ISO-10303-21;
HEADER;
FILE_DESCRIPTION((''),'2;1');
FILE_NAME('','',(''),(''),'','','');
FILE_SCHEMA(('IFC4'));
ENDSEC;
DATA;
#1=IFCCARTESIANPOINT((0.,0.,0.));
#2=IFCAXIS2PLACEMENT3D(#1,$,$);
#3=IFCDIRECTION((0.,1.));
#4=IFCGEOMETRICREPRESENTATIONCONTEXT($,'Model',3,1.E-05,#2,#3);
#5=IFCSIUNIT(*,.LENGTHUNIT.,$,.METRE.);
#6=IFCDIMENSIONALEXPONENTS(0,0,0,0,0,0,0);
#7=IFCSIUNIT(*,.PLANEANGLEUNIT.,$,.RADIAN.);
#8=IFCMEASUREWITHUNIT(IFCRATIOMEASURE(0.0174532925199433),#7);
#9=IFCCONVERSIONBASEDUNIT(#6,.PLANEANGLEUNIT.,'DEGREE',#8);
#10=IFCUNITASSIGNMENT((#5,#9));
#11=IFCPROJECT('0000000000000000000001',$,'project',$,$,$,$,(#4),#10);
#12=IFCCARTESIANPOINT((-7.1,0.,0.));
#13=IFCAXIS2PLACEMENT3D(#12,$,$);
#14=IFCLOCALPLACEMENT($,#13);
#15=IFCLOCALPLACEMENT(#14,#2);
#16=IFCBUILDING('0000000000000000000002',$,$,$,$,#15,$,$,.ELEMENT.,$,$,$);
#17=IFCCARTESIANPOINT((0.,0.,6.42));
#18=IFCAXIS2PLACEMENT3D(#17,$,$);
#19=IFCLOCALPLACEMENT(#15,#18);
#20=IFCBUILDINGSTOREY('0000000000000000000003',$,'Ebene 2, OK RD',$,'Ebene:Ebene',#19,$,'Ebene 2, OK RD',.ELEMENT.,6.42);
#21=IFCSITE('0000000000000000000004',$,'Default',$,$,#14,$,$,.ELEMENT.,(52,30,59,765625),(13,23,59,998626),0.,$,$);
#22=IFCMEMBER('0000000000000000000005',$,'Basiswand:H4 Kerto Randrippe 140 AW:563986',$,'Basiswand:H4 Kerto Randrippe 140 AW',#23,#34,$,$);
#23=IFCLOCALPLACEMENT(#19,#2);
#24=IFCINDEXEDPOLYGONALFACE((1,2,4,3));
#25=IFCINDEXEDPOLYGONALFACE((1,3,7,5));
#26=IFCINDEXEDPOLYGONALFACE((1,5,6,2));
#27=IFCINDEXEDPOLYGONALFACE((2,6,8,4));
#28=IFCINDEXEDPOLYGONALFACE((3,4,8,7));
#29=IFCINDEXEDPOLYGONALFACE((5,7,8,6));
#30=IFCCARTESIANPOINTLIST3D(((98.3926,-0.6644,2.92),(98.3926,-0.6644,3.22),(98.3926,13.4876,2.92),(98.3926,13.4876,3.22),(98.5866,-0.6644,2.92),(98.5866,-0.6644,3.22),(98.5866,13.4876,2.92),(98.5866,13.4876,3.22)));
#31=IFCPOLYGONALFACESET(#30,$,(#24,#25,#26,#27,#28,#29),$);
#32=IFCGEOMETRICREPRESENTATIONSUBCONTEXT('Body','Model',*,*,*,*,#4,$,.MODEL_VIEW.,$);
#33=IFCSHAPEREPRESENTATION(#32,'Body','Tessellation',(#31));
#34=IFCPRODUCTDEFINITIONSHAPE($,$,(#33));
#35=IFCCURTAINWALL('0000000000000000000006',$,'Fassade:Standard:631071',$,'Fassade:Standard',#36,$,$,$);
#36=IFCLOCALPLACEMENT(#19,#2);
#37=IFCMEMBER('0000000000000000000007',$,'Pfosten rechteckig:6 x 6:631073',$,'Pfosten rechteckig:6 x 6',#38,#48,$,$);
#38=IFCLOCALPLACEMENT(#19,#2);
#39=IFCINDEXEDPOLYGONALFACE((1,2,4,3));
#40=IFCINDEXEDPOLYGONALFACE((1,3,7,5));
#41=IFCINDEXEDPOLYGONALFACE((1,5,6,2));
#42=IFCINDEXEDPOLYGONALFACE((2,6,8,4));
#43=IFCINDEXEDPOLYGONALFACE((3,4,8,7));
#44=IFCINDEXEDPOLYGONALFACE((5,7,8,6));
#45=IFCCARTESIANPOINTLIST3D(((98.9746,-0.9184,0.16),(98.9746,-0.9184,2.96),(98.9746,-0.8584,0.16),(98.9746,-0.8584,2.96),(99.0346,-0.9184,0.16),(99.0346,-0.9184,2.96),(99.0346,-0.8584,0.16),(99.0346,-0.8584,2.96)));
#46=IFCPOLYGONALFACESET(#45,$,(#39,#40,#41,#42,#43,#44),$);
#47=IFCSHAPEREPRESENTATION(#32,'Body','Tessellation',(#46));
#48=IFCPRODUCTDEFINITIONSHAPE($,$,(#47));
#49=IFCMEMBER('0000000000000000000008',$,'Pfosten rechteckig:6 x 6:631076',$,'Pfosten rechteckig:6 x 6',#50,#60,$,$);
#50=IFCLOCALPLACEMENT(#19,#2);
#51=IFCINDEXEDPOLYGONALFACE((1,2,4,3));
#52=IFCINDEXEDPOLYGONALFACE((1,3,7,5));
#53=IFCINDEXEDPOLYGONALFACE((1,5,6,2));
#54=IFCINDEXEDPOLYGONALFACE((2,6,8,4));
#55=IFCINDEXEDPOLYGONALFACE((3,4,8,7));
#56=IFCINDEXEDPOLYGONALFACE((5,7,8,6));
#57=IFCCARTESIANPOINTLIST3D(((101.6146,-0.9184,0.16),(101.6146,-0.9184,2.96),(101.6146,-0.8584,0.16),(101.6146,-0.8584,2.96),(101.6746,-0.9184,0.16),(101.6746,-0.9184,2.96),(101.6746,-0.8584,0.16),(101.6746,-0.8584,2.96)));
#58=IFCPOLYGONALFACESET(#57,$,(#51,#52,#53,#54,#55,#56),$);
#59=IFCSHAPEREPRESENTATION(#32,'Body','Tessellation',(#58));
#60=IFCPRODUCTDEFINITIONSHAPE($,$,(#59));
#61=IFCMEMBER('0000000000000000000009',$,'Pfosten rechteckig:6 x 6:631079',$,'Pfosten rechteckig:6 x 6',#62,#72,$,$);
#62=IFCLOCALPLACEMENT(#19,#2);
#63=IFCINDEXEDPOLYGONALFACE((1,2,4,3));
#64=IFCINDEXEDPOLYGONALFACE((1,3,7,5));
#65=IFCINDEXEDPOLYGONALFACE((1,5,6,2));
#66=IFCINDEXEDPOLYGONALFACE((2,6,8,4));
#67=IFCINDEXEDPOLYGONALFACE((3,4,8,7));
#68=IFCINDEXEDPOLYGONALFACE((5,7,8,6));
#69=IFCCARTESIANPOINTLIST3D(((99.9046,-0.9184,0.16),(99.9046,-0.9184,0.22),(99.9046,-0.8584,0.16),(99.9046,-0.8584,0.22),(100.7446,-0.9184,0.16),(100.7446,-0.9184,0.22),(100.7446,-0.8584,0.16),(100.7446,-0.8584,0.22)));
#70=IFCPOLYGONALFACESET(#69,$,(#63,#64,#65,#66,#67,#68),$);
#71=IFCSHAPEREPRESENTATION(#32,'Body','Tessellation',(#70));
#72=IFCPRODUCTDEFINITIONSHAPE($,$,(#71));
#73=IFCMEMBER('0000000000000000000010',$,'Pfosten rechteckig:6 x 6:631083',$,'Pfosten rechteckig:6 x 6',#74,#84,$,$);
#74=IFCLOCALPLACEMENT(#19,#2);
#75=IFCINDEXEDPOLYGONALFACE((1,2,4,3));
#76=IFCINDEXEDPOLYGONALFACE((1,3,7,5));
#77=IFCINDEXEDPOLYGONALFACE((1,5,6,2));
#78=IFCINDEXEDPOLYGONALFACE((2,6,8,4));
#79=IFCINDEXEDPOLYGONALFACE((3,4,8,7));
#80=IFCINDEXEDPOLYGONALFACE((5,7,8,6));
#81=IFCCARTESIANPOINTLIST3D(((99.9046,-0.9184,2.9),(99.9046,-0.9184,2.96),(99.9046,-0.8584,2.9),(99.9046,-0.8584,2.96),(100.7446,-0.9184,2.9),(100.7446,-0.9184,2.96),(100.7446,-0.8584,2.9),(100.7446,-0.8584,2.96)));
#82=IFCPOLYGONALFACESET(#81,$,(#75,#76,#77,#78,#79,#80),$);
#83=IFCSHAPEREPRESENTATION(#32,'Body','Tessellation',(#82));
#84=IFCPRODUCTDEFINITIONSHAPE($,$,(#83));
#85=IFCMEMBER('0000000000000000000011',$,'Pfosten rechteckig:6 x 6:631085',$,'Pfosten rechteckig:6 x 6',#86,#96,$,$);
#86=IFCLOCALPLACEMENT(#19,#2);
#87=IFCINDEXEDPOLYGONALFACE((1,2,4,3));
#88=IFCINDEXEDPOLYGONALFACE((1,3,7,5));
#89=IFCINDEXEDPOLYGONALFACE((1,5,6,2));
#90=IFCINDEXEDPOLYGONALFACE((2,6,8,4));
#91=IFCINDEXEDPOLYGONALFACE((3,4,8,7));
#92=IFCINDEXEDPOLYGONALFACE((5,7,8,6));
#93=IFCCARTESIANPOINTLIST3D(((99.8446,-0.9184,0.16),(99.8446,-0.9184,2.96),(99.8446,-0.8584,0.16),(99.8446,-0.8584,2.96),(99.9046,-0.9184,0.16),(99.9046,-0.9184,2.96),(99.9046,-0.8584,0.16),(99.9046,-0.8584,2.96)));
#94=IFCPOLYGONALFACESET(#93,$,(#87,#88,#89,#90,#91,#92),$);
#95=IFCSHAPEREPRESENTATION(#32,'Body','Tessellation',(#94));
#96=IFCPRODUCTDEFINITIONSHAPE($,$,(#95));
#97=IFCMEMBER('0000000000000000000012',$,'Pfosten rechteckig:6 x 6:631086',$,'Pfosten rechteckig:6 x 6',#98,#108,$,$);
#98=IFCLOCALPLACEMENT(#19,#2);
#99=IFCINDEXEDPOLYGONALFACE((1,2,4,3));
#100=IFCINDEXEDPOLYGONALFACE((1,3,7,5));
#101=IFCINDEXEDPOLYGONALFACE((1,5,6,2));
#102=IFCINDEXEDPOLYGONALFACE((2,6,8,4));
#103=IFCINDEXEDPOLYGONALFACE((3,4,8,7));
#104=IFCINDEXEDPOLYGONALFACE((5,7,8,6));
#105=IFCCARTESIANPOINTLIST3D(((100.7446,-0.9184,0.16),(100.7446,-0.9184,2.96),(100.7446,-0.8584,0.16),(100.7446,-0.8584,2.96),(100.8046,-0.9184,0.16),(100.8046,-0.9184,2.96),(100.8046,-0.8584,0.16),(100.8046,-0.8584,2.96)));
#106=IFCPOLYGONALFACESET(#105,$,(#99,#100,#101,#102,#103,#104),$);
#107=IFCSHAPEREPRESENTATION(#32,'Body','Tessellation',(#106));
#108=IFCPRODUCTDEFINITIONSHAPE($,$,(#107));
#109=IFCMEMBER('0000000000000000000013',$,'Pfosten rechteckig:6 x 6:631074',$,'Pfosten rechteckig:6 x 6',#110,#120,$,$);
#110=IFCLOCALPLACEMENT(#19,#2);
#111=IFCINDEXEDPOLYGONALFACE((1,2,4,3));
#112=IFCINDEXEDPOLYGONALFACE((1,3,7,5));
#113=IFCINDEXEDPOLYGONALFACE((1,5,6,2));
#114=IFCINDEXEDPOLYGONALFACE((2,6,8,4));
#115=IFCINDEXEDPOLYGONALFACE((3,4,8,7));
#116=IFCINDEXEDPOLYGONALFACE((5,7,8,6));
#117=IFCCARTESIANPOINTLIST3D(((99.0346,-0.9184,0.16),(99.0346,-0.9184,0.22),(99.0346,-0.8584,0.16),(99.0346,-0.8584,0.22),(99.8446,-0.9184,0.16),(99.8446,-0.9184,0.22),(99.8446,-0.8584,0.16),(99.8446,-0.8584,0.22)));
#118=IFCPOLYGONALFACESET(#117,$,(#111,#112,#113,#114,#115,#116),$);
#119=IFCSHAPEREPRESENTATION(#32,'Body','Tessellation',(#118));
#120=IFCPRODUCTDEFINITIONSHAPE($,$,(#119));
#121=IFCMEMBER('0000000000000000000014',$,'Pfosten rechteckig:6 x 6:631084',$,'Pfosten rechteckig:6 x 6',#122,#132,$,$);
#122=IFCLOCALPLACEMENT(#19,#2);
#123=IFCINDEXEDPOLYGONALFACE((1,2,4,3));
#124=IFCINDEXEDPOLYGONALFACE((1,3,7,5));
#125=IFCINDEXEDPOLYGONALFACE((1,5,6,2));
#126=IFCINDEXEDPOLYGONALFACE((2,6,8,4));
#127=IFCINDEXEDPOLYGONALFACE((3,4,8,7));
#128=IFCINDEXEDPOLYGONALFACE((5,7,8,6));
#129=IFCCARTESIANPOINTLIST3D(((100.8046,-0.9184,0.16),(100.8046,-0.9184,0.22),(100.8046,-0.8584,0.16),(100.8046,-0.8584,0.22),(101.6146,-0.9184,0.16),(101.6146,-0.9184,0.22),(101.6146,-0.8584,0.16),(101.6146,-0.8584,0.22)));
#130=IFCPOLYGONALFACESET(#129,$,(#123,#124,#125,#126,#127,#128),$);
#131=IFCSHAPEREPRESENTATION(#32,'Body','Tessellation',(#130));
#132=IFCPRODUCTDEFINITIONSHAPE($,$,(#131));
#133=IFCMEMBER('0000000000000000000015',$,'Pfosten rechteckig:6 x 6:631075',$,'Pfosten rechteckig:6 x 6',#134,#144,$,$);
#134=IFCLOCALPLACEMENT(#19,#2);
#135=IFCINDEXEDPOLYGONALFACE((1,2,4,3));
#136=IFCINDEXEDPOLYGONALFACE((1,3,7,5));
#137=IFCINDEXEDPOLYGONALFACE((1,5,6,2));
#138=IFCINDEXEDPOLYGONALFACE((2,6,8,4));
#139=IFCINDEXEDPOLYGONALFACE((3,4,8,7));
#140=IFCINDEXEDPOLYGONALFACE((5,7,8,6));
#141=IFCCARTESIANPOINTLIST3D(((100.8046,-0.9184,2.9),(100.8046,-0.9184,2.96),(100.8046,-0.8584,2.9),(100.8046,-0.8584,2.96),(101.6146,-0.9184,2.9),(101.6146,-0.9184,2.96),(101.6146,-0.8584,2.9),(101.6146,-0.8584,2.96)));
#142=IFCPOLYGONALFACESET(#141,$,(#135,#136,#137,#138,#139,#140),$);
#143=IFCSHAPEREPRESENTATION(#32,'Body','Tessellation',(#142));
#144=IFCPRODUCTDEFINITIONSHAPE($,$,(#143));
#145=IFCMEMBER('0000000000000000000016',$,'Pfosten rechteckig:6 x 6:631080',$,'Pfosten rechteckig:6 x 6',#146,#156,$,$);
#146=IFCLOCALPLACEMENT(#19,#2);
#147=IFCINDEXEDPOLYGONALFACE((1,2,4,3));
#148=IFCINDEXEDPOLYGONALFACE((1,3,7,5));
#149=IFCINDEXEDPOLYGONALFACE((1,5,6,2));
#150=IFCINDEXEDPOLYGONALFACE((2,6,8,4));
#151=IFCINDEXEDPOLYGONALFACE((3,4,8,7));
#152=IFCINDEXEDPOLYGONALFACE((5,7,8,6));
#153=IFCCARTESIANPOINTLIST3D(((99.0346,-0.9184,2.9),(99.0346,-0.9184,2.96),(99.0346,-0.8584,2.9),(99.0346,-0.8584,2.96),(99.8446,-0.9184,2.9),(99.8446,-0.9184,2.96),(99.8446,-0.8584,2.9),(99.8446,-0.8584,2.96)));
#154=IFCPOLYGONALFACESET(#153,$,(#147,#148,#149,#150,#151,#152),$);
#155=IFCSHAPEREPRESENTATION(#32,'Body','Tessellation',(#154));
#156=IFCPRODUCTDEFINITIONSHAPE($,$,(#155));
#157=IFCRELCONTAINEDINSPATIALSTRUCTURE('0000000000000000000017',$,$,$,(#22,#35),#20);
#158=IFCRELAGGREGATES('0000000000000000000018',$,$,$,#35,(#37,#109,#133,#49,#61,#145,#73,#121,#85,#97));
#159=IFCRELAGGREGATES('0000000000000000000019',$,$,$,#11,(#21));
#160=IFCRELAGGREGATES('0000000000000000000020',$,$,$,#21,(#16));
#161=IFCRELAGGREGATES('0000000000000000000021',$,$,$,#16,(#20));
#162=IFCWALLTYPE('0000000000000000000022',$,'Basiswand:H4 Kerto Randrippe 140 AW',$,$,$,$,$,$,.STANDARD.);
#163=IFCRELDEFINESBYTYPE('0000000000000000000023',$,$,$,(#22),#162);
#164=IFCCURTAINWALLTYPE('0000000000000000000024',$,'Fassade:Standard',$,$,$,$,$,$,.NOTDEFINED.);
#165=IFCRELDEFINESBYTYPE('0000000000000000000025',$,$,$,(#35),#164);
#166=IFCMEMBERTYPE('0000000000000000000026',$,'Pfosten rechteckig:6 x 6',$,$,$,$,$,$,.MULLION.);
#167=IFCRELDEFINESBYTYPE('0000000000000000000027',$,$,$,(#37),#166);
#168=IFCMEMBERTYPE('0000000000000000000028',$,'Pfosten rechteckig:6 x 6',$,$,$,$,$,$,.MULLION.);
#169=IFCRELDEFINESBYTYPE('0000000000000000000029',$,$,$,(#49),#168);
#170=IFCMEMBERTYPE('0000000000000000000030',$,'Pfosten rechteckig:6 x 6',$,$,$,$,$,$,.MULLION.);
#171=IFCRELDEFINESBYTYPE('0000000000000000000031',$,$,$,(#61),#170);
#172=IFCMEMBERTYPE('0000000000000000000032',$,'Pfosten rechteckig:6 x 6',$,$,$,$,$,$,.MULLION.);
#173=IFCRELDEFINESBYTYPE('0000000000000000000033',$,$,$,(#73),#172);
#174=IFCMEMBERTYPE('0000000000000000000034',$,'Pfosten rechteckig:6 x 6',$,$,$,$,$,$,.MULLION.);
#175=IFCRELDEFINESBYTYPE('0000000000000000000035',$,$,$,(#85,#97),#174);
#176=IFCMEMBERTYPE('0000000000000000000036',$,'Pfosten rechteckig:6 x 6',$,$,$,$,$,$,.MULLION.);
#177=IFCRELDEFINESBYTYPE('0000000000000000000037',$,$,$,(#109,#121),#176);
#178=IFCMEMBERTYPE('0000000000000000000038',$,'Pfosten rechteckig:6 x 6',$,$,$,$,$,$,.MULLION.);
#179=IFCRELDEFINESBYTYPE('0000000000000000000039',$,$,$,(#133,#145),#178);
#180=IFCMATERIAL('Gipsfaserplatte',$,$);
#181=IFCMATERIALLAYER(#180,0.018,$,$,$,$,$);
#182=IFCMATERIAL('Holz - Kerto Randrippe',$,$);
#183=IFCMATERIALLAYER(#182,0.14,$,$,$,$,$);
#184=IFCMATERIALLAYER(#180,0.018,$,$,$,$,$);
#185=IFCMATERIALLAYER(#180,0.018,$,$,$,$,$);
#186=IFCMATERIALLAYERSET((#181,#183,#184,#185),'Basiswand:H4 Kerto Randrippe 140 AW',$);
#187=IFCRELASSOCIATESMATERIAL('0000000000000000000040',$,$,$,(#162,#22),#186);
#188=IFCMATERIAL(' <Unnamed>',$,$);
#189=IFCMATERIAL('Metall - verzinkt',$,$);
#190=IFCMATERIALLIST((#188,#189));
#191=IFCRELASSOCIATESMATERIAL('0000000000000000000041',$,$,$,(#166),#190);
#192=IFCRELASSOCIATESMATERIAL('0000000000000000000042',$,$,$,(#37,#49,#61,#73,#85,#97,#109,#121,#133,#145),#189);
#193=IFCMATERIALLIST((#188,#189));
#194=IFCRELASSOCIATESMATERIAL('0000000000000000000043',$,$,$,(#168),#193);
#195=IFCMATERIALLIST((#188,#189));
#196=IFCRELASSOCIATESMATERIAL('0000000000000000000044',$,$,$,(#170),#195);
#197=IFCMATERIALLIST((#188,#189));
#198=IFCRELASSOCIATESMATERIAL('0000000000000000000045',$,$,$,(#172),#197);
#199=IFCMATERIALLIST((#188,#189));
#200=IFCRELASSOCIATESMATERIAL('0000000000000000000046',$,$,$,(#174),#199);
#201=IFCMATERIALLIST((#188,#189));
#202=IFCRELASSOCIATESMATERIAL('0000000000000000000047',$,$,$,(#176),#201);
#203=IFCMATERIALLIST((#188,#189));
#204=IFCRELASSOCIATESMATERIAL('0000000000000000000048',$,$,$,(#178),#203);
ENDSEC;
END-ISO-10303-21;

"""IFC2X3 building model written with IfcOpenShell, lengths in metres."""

from ifc_helpers import new_model, entity, si_unit, converted_unit, direction, frame, frame_2d, origin, origin_2d_with_axis, place, context, subcontext, project, spatial, rectangle, extrude, source, transform, mapped, material, material_list, layer, layer_set, layer_usage, type_object, type_shapes, element, aggregate, save


model = new_model("IFC2X3")

# Units and contexts
model_context = context("Model", 3, precision=1e-05, world=origin(), true_north=direction((0.0, 1.0)))
body_context = subcontext(model_context, "Body", "Model", "MODEL_VIEW")
ifc_project = project(units=[si_unit("LENGTHUNIT", "METRE"), converted_unit("PLANEANGLEUNIT", "DEGREE", entity("IfcRatioMeasure", 0.0174532925199433), si_unit("PLANEANGLEUNIT", "RADIAN"), dimensions=[0, 0, 0, 0, 0, 0, 0])], contexts=[model_context])

# Site, building, storey
site_placement = place(None, frame((-7.1, 0.0, 0.0)))
site = spatial("IfcSite", under=ifc_project, at=site_placement, Name="Default", CompositionType="ELEMENT", RefLatitude=(52, 30, 59, 765625), RefLongitude=(13, 23, 59, 998626), RefElevation=0.0)
building_placement = place(site_placement, origin())
building = spatial("IfcBuilding", under=site, at=building_placement, CompositionType="ELEMENT")
storey_placement = place(building_placement, frame((0.0, 0.0, 6.42)))
storey = spatial("IfcBuildingStorey", under=building, at=storey_placement, Name="Ebene 2, OK RD", ObjectType="Ebene:Ebene", LongName="Ebene 2, OK RD", CompositionType="ELEMENT", Elevation=6.42)

# Member
ifc_material_1 = material(Name="Gipsfaserplatte")
ifc_layer_1 = layer(ifc_material_1, 0.018)
ifc_material_2 = material(Name="Holz - Kerto Randrippe")
ifc_layer_2 = layer(ifc_material_2, 0.14)
ifc_layer_3 = layer(ifc_material_1, 0.018)
ifc_layer_4 = layer(ifc_material_1, 0.018)
ifc_layer_set_1 = layer_set([ifc_layer_1, ifc_layer_2, ifc_layer_3, ifc_layer_4], Name="Basiswand:H4 Kerto Randrippe 140 AW")
ifc_layer_usage_1 = layer_usage(ifc_layer_set_1, "AXIS2", "NEGATIVE", 0.097)
wall_type_1 = type_object("IfcWallType", Name="Basiswand:H4 Kerto Randrippe 140 AW", PredefinedType="STANDARD", material=ifc_layer_set_1)
member_1_placement = place(storey_placement, frame((98.4896, -0.6644, 2.92), z_axis=(0.0, 0.0, 1.0), x_axis=(0.0, 1.0, 0.0)))
element("IfcMember", 1, at=member_1_placement, inside=storey, type_object=wall_type_1, material=ifc_layer_usage_1, Name="Basiswand:H4 Kerto Randrippe 140 AW:563986", ObjectType="Basiswand:H4 Kerto Randrippe 140 AW", context=body_context, shape_type="SweptSolid", body=[
    extrude(rectangle(XDim=14.152, YDim=0.194, at=frame_2d((7.076, 0.0), x_axis=(-1.0, 0.0))), origin(), (0.0, 0.0, 1.0), 0.3),
])

# Curtain wall, members
curtain_wall_type = type_object("IfcCurtainWallType", Name="Fassade:Standard", PredefinedType="NOTDEFINED")
curtain_wall_placement = place(storey_placement, frame((0.0, 0.0, -6.42)))
curtain_wall = element("IfcCurtainWall", 2, at=curtain_wall_placement, inside=storey, type_object=curtain_wall_type, Name="Fassade:Standard:631071", ObjectType="Fassade:Standard")
ifc_material_3 = material(Name="Metall - verzinkt")
ifc_material_4 = material(Name=" <Unnamed>")
ifc_material_list_1 = material_list([ifc_material_4, ifc_material_3])
member_type_1 = type_object("IfcMemberType", Name="Pfosten rechteckig:6 x 6", PredefinedType="MULLION", material=ifc_material_list_1)
shared_shape_1 = source(origin(), body_context, "Body", "SweptSolid", [
    extrude(rectangle(XDim=0.06, YDim=0.06, at=origin_2d_with_axis()), frame((-0.03, 0.0, -2.8), z_axis=(0.0, 0.0, 1.0), x_axis=(0.0, -1.0, 0.0)), (0.0, 0.0, 1.0), 2.8),
])
type_shapes(member_type_1, [shared_shape_1])
placement = place(building_placement, frame((0.0, 0.0, 3.26)))
member_2_placement = place(placement, frame((98.9746, -0.8884, 6.12), z_axis=(0.0, 0.0, 1.0), x_axis=(-1.0, 0.0, 0.0)))
member_2 = element("IfcMember", 3, at=member_2_placement, type_object=member_type_1, material=ifc_material_3, Name="Pfosten rechteckig:6 x 6:631073", ObjectType="Pfosten rechteckig:6 x 6", context=body_context, shape_type="MappedRepresentation", body=[
    mapped(shared_shape_1, transform((0.0, 0.0, 0.0), scale=1.0)),
])
ifc_material_list_2 = material_list([ifc_material_4, ifc_material_3])
member_type_2 = type_object("IfcMemberType", Name="Pfosten rechteckig:6 x 6", PredefinedType="MULLION", material=ifc_material_list_2)
shared_shape_2 = source(origin(), body_context, "Body", "SweptSolid", [
    extrude(rectangle(XDim=0.06, YDim=0.06, at=origin_2d_with_axis()), frame((-0.03, 0.0, -2.8), z_axis=(0.0, 0.0, 1.0), x_axis=(0.0, -1.0, 0.0)), (0.0, 0.0, 1.0), 2.8),
])
type_shapes(member_type_2, [shared_shape_2])
member_3_placement = place(placement, frame((101.6746, -0.8884, 3.32), z_axis=(0.0, 0.0, -1.0), x_axis=(1.0, 0.0, 0.0)))
member_3 = element("IfcMember", 4, at=member_3_placement, type_object=member_type_2, material=ifc_material_3, Name="Pfosten rechteckig:6 x 6:631076", ObjectType="Pfosten rechteckig:6 x 6", context=body_context, shape_type="MappedRepresentation", body=[
    mapped(shared_shape_2, transform((0.0, 0.0, 0.0), scale=1.0)),
])
ifc_material_list_3 = material_list([ifc_material_4, ifc_material_3])
member_type_3 = type_object("IfcMemberType", Name="Pfosten rechteckig:6 x 6", PredefinedType="MULLION", material=ifc_material_list_3)
shared_shape_3 = source(origin(), body_context, "Body", "SweptSolid", [
    extrude(rectangle(XDim=0.06, YDim=0.06, at=origin_2d_with_axis()), frame((-0.03, 0.0, -0.84), z_axis=(0.0, 0.0, 1.0), x_axis=(0.0, -1.0, 0.0)), (0.0, 0.0, 1.0), 0.84),
])
type_shapes(member_type_3, [shared_shape_3])
member_4_placement = place(placement, frame((99.9046, -0.8884, 3.32), z_axis=(-1.0, 0.0, 0.0), x_axis=(0.0, 0.0, -1.0)))
member_4 = element("IfcMember", 5, at=member_4_placement, type_object=member_type_3, material=ifc_material_3, Name="Pfosten rechteckig:6 x 6:631079", ObjectType="Pfosten rechteckig:6 x 6", context=body_context, shape_type="MappedRepresentation", body=[
    mapped(shared_shape_3, transform((0.0, 0.0, 0.0), scale=1.0)),
])
ifc_material_list_4 = material_list([ifc_material_4, ifc_material_3])
member_type_4 = type_object("IfcMemberType", Name="Pfosten rechteckig:6 x 6", PredefinedType="MULLION", material=ifc_material_list_4)
shared_shape_4 = source(origin(), body_context, "Body", "SweptSolid", [
    extrude(rectangle(XDim=0.06, YDim=0.06, at=origin_2d_with_axis()), frame((-0.03, 0.0, -0.84), z_axis=(0.0, 0.0, 1.0), x_axis=(0.0, -1.0, 0.0)), (0.0, 0.0, 1.0), 0.84),
])
type_shapes(member_type_4, [shared_shape_4])
member_5_placement = place(placement, frame((100.7446, -0.8884, 6.12), z_axis=(1.0, 0.0, 0.0), x_axis=(0.0, 0.0, 1.0)))
member_5 = element("IfcMember", 6, at=member_5_placement, type_object=member_type_4, material=ifc_material_3, Name="Pfosten rechteckig:6 x 6:631083", ObjectType="Pfosten rechteckig:6 x 6", context=body_context, shape_type="MappedRepresentation", body=[
    mapped(shared_shape_4, transform((0.0, 0.0, 0.0), scale=1.0)),
])
ifc_material_list_5 = material_list([ifc_material_4, ifc_material_3])
member_type_5 = type_object("IfcMemberType", Name="Pfosten rechteckig:6 x 6", PredefinedType="MULLION", material=ifc_material_list_5)
shared_shape_5 = source(origin(), body_context, "Body", "SweptSolid", [
    extrude(rectangle(XDim=0.06, YDim=0.06, at=origin_2d_with_axis()), frame((0.0, 0.0, -2.8), z_axis=(0.0, 0.0, 1.0), x_axis=(0.0, -1.0, 0.0)), (0.0, 0.0, 1.0), 2.8),
])
type_shapes(member_type_5, [shared_shape_5])
member_6_placement = place(placement, frame((99.8746, -0.8884, 3.32), z_axis=(0.0, 0.0, -1.0), x_axis=(1.0, 0.0, 0.0)))
member_6 = element("IfcMember", 7, at=member_6_placement, type_object=member_type_5, material=ifc_material_3, Name="Pfosten rechteckig:6 x 6:631085", ObjectType="Pfosten rechteckig:6 x 6", context=body_context, shape_type="MappedRepresentation", body=[
    mapped(shared_shape_5, transform((0.0, 0.0, 0.0), scale=1.0)),
])
member_7_placement = place(placement, frame((100.7746, -0.8884, 3.32), z_axis=(0.0, 0.0, -1.0), x_axis=(1.0, 0.0, 0.0)))
member_7 = element("IfcMember", 8, at=member_7_placement, type_object=member_type_5, material=ifc_material_3, Name="Pfosten rechteckig:6 x 6:631086", ObjectType="Pfosten rechteckig:6 x 6", context=body_context, shape_type="MappedRepresentation", body=[
    mapped(shared_shape_5, transform((0.0, 0.0, 0.0), scale=1.0)),
])
ifc_material_list_6 = material_list([ifc_material_4, ifc_material_3])
member_type_6 = type_object("IfcMemberType", Name="Pfosten rechteckig:6 x 6", PredefinedType="MULLION", material=ifc_material_list_6)
shared_shape_6 = source(origin(), body_context, "Body", "SweptSolid", [
    extrude(rectangle(XDim=0.06, YDim=0.06, at=origin_2d_with_axis()), frame((-0.03, 0.0, -0.81), z_axis=(0.0, 0.0, 1.0), x_axis=(0.0, -1.0, 0.0)), (0.0, 0.0, 1.0), 0.81),
])
type_shapes(member_type_6, [shared_shape_6])
member_8_placement = place(placement, frame((99.0346, -0.8884, 3.32), z_axis=(-1.0, 0.0, 0.0), x_axis=(0.0, 0.0, -1.0)))
member_8 = element("IfcMember", 9, at=member_8_placement, type_object=member_type_6, material=ifc_material_3, Name="Pfosten rechteckig:6 x 6:631074", ObjectType="Pfosten rechteckig:6 x 6", context=body_context, shape_type="MappedRepresentation", body=[
    mapped(shared_shape_6, transform((0.0, 0.0, 0.0), scale=1.0)),
])
member_9_placement = place(placement, frame((100.8046, -0.8884, 3.32), z_axis=(-1.0, 0.0, 0.0), x_axis=(0.0, 0.0, -1.0)))
member_9 = element("IfcMember", 10, at=member_9_placement, type_object=member_type_6, material=ifc_material_3, Name="Pfosten rechteckig:6 x 6:631084", ObjectType="Pfosten rechteckig:6 x 6", context=body_context, shape_type="MappedRepresentation", body=[
    mapped(shared_shape_6, transform((0.0, 0.0, 0.0), scale=1.0)),
])
ifc_material_list_7 = material_list([ifc_material_4, ifc_material_3])
member_type_7 = type_object("IfcMemberType", Name="Pfosten rechteckig:6 x 6", PredefinedType="MULLION", material=ifc_material_list_7)
shared_shape_7 = source(origin(), body_context, "Body", "SweptSolid", [
    extrude(rectangle(XDim=0.06, YDim=0.06, at=origin_2d_with_axis()), frame((-0.03, 0.0, -0.81), z_axis=(0.0, 0.0, 1.0), x_axis=(0.0, -1.0, 0.0)), (0.0, 0.0, 1.0), 0.81),
])
type_shapes(member_type_7, [shared_shape_7])
member_10_placement = place(placement, frame((101.6146, -0.8884, 6.12), z_axis=(1.0, 0.0, 0.0), x_axis=(0.0, 0.0, 1.0)))
member_10 = element("IfcMember", 11, at=member_10_placement, type_object=member_type_7, material=ifc_material_3, Name="Pfosten rechteckig:6 x 6:631075", ObjectType="Pfosten rechteckig:6 x 6", context=body_context, shape_type="MappedRepresentation", body=[
    mapped(shared_shape_7, transform((0.0, 0.0, 0.0), scale=1.0)),
])
member_11_placement = place(placement, frame((99.8446, -0.8884, 6.12), z_axis=(1.0, 0.0, 0.0), x_axis=(0.0, 0.0, 1.0)))
member_11 = element("IfcMember", 12, at=member_11_placement, type_object=member_type_7, material=ifc_material_3, Name="Pfosten rechteckig:6 x 6:631080", ObjectType="Pfosten rechteckig:6 x 6", context=body_context, shape_type="MappedRepresentation", body=[
    mapped(shared_shape_7, transform((0.0, 0.0, 0.0), scale=1.0)),
])

aggregate(curtain_wall, [member_2, member_8, member_10, member_3, member_4, member_11, member_5, member_9, member_6, member_7])

save(model, "model.ifc")
